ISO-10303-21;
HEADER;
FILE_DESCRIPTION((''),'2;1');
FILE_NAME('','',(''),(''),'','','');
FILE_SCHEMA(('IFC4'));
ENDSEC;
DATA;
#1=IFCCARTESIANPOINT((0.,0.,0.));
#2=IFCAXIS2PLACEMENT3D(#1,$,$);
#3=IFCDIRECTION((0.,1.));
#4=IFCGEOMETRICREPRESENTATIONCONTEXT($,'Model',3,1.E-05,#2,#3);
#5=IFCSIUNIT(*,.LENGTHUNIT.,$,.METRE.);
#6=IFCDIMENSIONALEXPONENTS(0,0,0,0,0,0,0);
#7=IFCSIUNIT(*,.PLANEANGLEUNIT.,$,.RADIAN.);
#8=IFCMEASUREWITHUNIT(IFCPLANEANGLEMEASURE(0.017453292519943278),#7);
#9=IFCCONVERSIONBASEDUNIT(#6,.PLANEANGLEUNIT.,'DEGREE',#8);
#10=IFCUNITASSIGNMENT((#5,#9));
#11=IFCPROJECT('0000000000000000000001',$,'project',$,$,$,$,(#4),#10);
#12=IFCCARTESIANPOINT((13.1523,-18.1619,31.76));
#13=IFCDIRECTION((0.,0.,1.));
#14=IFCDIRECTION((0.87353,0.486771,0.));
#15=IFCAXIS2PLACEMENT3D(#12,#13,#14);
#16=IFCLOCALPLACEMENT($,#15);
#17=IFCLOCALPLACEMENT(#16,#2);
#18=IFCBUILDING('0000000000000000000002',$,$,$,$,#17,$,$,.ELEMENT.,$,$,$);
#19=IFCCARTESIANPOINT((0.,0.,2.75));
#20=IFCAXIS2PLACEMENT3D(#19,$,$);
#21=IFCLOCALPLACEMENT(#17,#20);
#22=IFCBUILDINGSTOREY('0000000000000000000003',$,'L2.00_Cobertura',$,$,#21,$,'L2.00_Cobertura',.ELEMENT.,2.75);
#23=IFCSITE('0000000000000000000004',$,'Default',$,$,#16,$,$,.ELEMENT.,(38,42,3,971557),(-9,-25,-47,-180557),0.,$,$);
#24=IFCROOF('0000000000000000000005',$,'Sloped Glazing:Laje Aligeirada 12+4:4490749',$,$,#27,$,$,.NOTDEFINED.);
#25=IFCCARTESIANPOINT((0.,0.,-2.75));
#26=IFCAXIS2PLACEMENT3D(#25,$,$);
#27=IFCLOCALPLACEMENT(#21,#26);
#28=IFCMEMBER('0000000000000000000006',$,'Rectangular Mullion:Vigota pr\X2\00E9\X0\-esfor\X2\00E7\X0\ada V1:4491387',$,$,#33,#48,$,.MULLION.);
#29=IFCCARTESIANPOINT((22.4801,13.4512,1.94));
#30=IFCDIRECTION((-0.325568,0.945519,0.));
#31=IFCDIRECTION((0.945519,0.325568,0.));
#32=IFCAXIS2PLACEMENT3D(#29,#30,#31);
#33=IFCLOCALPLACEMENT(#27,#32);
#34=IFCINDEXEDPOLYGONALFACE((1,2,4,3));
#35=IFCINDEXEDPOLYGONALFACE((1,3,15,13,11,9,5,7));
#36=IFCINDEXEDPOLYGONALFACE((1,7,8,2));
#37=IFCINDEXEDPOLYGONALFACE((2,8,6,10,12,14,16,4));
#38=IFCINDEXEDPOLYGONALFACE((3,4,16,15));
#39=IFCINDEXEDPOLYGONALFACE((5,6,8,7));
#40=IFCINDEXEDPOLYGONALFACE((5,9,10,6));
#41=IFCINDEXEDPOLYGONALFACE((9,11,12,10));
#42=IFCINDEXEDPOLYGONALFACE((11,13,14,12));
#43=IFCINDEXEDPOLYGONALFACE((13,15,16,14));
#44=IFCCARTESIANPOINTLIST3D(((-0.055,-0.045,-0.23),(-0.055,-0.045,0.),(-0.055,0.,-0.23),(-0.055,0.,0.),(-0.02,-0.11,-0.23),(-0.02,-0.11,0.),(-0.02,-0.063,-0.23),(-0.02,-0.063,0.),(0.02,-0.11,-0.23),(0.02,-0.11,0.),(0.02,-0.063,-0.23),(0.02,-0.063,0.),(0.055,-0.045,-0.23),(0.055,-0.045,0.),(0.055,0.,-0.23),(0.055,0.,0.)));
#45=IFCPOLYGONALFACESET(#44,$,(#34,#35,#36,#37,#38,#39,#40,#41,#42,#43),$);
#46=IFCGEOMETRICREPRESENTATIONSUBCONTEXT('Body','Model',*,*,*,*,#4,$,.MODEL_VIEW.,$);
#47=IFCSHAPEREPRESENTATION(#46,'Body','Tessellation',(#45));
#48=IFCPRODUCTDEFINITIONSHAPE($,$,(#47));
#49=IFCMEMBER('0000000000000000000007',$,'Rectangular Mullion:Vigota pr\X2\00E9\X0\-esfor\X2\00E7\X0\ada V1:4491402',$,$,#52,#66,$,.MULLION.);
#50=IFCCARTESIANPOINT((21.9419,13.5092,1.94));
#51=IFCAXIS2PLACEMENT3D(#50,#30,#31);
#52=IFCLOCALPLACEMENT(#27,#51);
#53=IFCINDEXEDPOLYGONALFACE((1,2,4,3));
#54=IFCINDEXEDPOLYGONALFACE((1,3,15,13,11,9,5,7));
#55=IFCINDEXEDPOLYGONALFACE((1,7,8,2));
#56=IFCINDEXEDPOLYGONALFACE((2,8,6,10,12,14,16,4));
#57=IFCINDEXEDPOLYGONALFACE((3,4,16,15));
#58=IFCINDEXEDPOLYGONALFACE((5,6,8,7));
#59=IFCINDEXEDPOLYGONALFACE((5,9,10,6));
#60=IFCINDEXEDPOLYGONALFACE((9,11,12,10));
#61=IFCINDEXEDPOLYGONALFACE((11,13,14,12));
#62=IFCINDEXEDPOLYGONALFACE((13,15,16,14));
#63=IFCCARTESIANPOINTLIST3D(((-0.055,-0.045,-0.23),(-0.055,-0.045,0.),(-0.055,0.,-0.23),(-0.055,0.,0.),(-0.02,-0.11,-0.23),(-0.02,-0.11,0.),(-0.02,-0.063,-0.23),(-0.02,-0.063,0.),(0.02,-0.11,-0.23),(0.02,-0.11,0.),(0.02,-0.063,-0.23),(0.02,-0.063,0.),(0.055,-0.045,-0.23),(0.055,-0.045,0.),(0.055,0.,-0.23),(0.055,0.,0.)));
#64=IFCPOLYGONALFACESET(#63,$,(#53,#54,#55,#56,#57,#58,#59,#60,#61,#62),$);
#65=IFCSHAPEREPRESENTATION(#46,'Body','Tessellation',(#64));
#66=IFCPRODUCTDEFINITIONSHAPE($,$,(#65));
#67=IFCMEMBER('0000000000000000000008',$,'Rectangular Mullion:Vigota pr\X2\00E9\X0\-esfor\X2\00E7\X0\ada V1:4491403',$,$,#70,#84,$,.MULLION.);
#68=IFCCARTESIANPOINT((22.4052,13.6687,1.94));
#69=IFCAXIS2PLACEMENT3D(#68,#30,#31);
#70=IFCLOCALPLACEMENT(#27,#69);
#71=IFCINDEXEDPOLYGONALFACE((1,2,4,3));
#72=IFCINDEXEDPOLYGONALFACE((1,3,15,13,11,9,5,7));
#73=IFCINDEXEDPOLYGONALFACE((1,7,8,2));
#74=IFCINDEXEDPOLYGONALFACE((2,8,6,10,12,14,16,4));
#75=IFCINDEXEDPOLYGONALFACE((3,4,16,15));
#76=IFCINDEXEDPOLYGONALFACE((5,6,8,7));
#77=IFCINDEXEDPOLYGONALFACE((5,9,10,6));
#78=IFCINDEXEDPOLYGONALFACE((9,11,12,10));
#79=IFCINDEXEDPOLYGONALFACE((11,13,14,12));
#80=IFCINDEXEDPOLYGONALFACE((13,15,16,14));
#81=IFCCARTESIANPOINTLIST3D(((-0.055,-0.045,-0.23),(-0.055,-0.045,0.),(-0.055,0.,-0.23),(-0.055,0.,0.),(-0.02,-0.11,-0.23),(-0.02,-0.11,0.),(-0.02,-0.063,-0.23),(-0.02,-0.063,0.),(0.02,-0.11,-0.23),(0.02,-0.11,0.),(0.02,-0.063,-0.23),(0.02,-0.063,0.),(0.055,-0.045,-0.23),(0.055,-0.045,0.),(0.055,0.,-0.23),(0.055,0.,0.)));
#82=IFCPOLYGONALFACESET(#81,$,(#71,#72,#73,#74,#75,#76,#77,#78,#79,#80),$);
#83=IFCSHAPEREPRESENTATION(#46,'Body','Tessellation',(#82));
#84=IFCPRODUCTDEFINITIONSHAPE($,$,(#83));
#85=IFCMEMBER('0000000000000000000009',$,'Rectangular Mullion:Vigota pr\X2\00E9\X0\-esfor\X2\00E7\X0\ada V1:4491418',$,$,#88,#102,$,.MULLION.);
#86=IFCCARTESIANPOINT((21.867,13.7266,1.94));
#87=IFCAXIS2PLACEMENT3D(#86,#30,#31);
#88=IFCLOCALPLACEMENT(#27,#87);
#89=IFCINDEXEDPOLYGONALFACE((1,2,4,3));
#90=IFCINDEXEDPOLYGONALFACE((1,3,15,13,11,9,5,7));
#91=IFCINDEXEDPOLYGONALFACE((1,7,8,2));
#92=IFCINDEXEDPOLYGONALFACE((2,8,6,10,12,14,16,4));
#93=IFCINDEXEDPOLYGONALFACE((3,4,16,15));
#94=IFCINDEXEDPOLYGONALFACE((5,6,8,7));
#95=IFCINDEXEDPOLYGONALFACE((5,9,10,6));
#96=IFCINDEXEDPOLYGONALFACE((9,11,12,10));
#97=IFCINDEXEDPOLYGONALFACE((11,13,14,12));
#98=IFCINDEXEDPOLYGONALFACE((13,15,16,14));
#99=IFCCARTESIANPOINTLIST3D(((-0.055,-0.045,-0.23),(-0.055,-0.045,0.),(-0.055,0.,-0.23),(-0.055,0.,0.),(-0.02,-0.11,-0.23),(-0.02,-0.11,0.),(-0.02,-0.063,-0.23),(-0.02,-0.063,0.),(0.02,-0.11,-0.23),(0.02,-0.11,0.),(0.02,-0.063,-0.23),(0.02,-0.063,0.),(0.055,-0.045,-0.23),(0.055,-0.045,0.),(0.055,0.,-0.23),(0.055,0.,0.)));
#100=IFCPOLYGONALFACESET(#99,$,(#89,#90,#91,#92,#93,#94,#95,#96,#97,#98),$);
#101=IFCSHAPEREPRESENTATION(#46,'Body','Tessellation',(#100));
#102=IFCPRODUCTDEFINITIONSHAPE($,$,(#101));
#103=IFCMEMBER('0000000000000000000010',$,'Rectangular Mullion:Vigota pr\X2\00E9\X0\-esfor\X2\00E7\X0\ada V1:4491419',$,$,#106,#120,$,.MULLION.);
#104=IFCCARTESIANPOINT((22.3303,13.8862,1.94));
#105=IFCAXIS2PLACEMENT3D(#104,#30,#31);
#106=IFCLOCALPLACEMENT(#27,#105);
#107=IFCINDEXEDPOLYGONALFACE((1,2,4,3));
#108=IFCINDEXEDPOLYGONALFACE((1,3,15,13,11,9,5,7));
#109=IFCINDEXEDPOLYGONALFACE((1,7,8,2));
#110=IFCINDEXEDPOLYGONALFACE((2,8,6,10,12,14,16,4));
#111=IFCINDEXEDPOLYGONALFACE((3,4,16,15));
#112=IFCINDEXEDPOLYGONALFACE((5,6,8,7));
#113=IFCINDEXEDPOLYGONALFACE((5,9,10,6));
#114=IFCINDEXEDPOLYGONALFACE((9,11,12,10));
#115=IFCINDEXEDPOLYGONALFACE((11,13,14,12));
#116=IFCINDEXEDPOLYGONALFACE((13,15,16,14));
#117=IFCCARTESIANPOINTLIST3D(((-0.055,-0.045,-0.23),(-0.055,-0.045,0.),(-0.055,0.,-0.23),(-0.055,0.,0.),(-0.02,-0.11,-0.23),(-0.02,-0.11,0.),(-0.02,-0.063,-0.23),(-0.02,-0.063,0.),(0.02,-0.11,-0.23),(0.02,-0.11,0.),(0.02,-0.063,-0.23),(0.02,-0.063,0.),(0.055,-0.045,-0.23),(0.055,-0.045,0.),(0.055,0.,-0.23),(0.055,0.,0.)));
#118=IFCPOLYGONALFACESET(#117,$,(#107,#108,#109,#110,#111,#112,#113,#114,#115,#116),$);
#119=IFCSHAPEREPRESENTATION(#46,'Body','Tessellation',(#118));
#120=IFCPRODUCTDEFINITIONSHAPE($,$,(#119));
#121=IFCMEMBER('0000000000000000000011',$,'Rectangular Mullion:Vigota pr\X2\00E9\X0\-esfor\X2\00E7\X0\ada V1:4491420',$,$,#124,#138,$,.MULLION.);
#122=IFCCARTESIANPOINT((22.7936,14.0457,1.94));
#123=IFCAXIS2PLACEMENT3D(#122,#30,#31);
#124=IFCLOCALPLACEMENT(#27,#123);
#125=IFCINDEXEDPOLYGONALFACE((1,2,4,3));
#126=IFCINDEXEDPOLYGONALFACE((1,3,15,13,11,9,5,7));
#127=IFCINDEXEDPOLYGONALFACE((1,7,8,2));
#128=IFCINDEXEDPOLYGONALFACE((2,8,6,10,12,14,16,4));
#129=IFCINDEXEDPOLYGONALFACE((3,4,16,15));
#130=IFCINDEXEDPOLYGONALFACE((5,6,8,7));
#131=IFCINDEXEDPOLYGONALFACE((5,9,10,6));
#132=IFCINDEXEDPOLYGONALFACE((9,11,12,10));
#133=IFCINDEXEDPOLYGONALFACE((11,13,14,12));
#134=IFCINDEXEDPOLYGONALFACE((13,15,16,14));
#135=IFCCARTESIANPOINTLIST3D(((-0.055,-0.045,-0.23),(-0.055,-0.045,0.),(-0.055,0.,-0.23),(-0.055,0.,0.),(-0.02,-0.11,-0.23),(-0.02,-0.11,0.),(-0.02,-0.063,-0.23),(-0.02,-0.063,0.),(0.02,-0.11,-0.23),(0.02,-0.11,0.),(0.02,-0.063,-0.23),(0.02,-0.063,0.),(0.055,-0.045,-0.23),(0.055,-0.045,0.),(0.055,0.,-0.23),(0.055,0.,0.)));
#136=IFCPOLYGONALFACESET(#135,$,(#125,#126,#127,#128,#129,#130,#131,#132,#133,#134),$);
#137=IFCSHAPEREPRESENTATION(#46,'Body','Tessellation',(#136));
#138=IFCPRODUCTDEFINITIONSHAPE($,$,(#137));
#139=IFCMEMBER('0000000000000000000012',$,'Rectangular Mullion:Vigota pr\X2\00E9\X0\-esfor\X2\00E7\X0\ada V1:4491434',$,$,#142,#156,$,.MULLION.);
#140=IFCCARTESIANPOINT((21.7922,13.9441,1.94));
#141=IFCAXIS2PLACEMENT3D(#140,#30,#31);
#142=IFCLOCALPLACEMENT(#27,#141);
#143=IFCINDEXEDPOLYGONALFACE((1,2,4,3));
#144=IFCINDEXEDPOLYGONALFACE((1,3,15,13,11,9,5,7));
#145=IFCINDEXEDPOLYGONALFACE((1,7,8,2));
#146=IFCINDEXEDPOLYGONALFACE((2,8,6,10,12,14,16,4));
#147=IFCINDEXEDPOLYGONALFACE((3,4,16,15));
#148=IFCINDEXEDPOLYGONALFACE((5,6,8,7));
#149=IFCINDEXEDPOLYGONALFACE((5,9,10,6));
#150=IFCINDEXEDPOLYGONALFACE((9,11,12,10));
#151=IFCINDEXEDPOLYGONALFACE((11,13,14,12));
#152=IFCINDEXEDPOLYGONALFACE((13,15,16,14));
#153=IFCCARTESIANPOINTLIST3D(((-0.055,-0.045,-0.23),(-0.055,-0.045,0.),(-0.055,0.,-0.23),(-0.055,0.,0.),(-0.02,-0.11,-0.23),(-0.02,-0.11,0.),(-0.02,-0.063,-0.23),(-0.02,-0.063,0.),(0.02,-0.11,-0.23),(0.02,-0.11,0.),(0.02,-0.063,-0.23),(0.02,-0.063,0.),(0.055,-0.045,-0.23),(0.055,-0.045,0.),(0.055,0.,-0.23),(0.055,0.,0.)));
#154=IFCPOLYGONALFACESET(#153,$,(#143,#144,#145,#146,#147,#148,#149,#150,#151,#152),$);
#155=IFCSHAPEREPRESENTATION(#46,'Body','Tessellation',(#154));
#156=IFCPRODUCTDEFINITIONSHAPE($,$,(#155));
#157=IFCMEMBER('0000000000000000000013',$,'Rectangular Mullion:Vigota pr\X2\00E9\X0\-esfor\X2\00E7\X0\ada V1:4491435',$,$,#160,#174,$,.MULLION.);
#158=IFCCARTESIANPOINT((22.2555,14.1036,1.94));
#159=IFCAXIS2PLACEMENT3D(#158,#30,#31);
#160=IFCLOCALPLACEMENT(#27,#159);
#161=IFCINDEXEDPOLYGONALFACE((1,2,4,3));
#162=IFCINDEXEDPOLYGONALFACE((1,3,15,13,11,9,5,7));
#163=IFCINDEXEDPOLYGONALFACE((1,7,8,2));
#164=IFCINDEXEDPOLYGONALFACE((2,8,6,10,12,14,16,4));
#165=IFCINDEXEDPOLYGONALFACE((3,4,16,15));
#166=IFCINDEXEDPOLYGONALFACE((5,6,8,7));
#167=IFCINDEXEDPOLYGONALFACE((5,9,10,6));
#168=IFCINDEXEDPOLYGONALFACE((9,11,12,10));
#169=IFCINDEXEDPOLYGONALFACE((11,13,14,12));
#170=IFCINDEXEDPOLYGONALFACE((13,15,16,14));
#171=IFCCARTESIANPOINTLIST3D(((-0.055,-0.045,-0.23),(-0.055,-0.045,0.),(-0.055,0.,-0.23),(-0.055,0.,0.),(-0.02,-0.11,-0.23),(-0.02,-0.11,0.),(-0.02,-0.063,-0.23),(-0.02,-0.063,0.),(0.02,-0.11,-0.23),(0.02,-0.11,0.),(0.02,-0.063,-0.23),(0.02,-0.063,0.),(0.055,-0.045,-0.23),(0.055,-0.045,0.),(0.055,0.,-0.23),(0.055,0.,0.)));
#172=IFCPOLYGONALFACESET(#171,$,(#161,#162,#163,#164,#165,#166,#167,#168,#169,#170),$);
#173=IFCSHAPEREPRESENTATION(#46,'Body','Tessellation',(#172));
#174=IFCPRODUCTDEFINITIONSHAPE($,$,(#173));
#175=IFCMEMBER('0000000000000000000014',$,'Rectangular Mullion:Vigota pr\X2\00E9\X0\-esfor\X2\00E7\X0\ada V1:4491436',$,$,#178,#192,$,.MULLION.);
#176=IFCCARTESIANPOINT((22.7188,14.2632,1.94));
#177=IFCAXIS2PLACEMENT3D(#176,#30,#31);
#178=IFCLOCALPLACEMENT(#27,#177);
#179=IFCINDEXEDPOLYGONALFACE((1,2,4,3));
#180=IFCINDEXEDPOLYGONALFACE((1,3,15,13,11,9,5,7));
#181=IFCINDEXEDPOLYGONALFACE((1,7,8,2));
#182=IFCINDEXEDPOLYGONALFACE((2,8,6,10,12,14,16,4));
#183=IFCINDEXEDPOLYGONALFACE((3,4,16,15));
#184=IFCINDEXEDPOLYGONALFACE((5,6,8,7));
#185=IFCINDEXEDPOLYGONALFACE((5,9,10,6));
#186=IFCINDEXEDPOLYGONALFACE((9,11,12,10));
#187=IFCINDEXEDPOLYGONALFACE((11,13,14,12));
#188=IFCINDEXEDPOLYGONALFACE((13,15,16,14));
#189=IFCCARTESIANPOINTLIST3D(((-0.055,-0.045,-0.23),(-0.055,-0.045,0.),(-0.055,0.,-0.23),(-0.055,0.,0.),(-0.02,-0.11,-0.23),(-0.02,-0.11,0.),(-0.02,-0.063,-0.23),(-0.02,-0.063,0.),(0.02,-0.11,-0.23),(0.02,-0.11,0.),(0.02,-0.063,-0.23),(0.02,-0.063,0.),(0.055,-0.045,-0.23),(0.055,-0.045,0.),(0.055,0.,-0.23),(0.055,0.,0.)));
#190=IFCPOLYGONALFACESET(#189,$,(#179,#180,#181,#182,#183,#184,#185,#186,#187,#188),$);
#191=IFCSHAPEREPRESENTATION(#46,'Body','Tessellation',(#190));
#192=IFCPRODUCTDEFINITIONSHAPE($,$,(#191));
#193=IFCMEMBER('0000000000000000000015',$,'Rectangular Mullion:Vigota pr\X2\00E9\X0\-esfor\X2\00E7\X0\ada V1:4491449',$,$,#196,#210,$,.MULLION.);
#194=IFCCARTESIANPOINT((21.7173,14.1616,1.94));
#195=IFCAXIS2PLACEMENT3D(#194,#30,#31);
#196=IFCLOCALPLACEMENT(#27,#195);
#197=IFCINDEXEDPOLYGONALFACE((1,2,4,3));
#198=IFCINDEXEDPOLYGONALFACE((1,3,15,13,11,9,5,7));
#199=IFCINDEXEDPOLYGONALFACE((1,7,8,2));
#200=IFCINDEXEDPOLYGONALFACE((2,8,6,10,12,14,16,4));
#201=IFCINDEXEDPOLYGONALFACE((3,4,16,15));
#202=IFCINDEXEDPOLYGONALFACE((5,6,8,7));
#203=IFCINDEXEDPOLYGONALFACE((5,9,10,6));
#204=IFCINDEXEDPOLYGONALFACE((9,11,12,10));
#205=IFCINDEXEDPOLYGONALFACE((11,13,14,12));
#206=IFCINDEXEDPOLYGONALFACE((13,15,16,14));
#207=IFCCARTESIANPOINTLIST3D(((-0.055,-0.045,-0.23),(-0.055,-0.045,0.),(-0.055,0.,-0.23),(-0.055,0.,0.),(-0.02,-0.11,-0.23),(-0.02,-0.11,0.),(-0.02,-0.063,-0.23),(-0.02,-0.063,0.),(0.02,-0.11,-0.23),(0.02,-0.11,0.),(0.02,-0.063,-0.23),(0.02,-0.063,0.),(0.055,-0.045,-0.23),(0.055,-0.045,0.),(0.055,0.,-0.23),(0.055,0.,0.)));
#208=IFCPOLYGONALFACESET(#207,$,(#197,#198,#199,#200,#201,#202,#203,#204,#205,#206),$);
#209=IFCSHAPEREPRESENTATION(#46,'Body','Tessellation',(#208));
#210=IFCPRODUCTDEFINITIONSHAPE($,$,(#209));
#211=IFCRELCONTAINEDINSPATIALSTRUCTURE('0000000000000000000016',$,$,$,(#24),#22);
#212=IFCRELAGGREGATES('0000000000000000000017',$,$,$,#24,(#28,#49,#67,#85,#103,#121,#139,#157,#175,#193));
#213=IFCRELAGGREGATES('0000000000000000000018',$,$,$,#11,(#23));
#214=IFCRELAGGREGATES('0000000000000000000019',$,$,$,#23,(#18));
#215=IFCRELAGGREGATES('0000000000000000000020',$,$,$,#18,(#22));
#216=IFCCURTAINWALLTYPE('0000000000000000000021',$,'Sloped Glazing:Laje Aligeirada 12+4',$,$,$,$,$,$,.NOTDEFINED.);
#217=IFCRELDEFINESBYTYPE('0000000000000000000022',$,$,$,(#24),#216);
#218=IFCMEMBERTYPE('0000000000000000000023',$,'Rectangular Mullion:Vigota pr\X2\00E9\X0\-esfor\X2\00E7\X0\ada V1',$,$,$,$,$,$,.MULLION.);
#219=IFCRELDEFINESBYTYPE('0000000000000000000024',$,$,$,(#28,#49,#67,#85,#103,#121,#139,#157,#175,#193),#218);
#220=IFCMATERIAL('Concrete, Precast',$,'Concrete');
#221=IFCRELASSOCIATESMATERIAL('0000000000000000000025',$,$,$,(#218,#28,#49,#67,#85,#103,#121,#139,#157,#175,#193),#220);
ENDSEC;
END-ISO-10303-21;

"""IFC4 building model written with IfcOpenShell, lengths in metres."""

from ifc_helpers import new_model, entity, si_unit, converted_unit, direction, frame, origin, place, context, subcontext, project, spatial, indexed_curve, outline, extrude, source, transform, mapped, material, type_object, type_shapes, element, aggregate, save


model = new_model("IFC4")

# Units and contexts
model_context = context("Model", 3, precision=1e-05, world=origin(), true_north=direction((0.0, 1.0)))
body_context = subcontext(model_context, "Body", "Model", "MODEL_VIEW")
ifc_project = project(units=[si_unit("LENGTHUNIT", "METRE"), converted_unit("PLANEANGLEUNIT", "DEGREE", entity("IfcPlaneAngleMeasure", 0.017453292519943278), si_unit("PLANEANGLEUNIT", "RADIAN"), dimensions=[0, 0, 0, 0, 0, 0, 0])], contexts=[model_context])

# Site, building, storey
site_placement = place(None, frame((13.1523, -18.1619, 31.76), z_axis=(0.0, 0.0, 1.0), x_axis=(0.87353, 0.486771, 0.0)))
site = spatial("IfcSite", under=ifc_project, at=site_placement, Name="Default", CompositionType="ELEMENT", RefLatitude=(38, 42, 3, 971557), RefLongitude=(-9, -25, -47, -180557), RefElevation=0.0)
building_placement = place(site_placement, origin())
building = spatial("IfcBuilding", under=site, at=building_placement, CompositionType="ELEMENT")
storey_placement = place(building_placement, frame((0.0, 0.0, 2.75)))
storey = spatial("IfcBuildingStorey", under=building, at=storey_placement, Name="L2.00_Cobertura", LongName="L2.00_Cobertura", CompositionType="ELEMENT", Elevation=2.75)

# Roof, members
curtain_wall_type = type_object("IfcCurtainWallType", Name="Sloped Glazing:Laje Aligeirada 12+4", PredefinedType="NOTDEFINED")
roof_placement = place(storey_placement, frame((0.0, 0.0, -2.75)))
roof = element("IfcRoof", 1, at=roof_placement, inside=storey, type_object=curtain_wall_type, Name="Sloped Glazing:Laje Aligeirada 12+4:4490749", PredefinedType="NOTDEFINED")
ifc_material_1 = material(Name="Concrete, Precast", Category="Concrete")
member_type_1 = type_object("IfcMemberType", Name="Rectangular Mullion:Vigota pré-esforçada V1", PredefinedType="MULLION", material=ifc_material_1)
shared_shape_1 = source(origin(), body_context, "Body", "SweptSolid", [
    extrude(outline(indexed_curve([(-0.055, -0.0545), (0.055, -0.0545), (0.055, -0.0095), (0.02, 0.0085), (0.02, 0.0555), (-0.02, 0.0555), (-0.02, 0.0085), (-0.055, -0.0095), (-0.055, -0.0545)], self_intersect=False)), frame((0.0, -0.0545, -0.23), z_axis=(0.0, 0.0, 1.0), x_axis=(-1.0, 0.0, 0.0)), (0.0, 0.0, 1.0), 0.23),
])
type_shapes(member_type_1, [shared_shape_1])
member_1_placement = place(roof_placement, frame((22.4801, 13.4512, 1.94), z_axis=(-0.325568, 0.945519, 0.0), x_axis=(0.945519, 0.325568, 0.0)))
member_1 = element("IfcMember", 2, at=member_1_placement, type_object=member_type_1, material=ifc_material_1, Name="Rectangular Mullion:Vigota pré-esforçada V1:4491387", PredefinedType="MULLION", context=body_context, shape_type="MappedRepresentation", body=[
    mapped(shared_shape_1, transform((0.0, 0.0, 0.0), scale=1.0)),
])
member_2_placement = place(roof_placement, frame((21.9419, 13.5092, 1.94), z_axis=(-0.325568, 0.945519, 0.0), x_axis=(0.945519, 0.325568, 0.0)))
member_2 = element("IfcMember", 3, at=member_2_placement, type_object=member_type_1, material=ifc_material_1, Name="Rectangular Mullion:Vigota pré-esforçada V1:4491402", PredefinedType="MULLION", context=body_context, shape_type="MappedRepresentation", body=[
    mapped(shared_shape_1, transform((0.0, 0.0, 0.0), scale=1.0)),
])
member_3_placement = place(roof_placement, frame((22.4052, 13.6687, 1.94), z_axis=(-0.325568, 0.945519, 0.0), x_axis=(0.945519, 0.325568, 0.0)))
member_3 = element("IfcMember", 4, at=member_3_placement, type_object=member_type_1, material=ifc_material_1, Name="Rectangular Mullion:Vigota pré-esforçada V1:4491403", PredefinedType="MULLION", context=body_context, shape_type="MappedRepresentation", body=[
    mapped(shared_shape_1, transform((0.0, 0.0, 0.0), scale=1.0)),
])
member_4_placement = place(roof_placement, frame((21.867, 13.7266, 1.94), z_axis=(-0.325568, 0.945519, 0.0), x_axis=(0.945519, 0.325568, 0.0)))
member_4 = element("IfcMember", 5, at=member_4_placement, type_object=member_type_1, material=ifc_material_1, Name="Rectangular Mullion:Vigota pré-esforçada V1:4491418", PredefinedType="MULLION", context=body_context, shape_type="MappedRepresentation", body=[
    mapped(shared_shape_1, transform((0.0, 0.0, 0.0), scale=1.0)),
])
member_5_placement = place(roof_placement, frame((22.3303, 13.8862, 1.94), z_axis=(-0.325568, 0.945519, 0.0), x_axis=(0.945519, 0.325568, 0.0)))
member_5 = element("IfcMember", 6, at=member_5_placement, type_object=member_type_1, material=ifc_material_1, Name="Rectangular Mullion:Vigota pré-esforçada V1:4491419", PredefinedType="MULLION", context=body_context, shape_type="MappedRepresentation", body=[
    mapped(shared_shape_1, transform((0.0, 0.0, 0.0), scale=1.0)),
])
member_6_placement = place(roof_placement, frame((22.7936, 14.0457, 1.94), z_axis=(-0.325568, 0.945519, 0.0), x_axis=(0.945519, 0.325568, 0.0)))
member_6 = element("IfcMember", 7, at=member_6_placement, type_object=member_type_1, material=ifc_material_1, Name="Rectangular Mullion:Vigota pré-esforçada V1:4491420", PredefinedType="MULLION", context=body_context, shape_type="MappedRepresentation", body=[
    mapped(shared_shape_1, transform((0.0, 0.0, 0.0), scale=1.0)),
])
member_7_placement = place(roof_placement, frame((21.7922, 13.9441, 1.94), z_axis=(-0.325568, 0.945519, 0.0), x_axis=(0.945519, 0.325568, 0.0)))
member_7 = element("IfcMember", 8, at=member_7_placement, type_object=member_type_1, material=ifc_material_1, Name="Rectangular Mullion:Vigota pré-esforçada V1:4491434", PredefinedType="MULLION", context=body_context, shape_type="MappedRepresentation", body=[
    mapped(shared_shape_1, transform((0.0, 0.0, 0.0), scale=1.0)),
])
member_8_placement = place(roof_placement, frame((22.2555, 14.1036, 1.94), z_axis=(-0.325568, 0.945519, 0.0), x_axis=(0.945519, 0.325568, 0.0)))
member_8 = element("IfcMember", 9, at=member_8_placement, type_object=member_type_1, material=ifc_material_1, Name="Rectangular Mullion:Vigota pré-esforçada V1:4491435", PredefinedType="MULLION", context=body_context, shape_type="MappedRepresentation", body=[
    mapped(shared_shape_1, transform((0.0, 0.0, 0.0), scale=1.0)),
])
member_9_placement = place(roof_placement, frame((22.7188, 14.2632, 1.94), z_axis=(-0.325568, 0.945519, 0.0), x_axis=(0.945519, 0.325568, 0.0)))
member_9 = element("IfcMember", 10, at=member_9_placement, type_object=member_type_1, material=ifc_material_1, Name="Rectangular Mullion:Vigota pré-esforçada V1:4491436", PredefinedType="MULLION", context=body_context, shape_type="MappedRepresentation", body=[
    mapped(shared_shape_1, transform((0.0, 0.0, 0.0), scale=1.0)),
])
member_10_placement = place(roof_placement, frame((21.7173, 14.1616, 1.94), z_axis=(-0.325568, 0.945519, 0.0), x_axis=(0.945519, 0.325568, 0.0)))
member_10 = element("IfcMember", 11, at=member_10_placement, type_object=member_type_1, material=ifc_material_1, Name="Rectangular Mullion:Vigota pré-esforçada V1:4491449", PredefinedType="MULLION", context=body_context, shape_type="MappedRepresentation", body=[
    mapped(shared_shape_1, transform((0.0, 0.0, 0.0), scale=1.0)),
])
aggregate(roof, [member_1, member_2, member_3, member_4, member_5, member_6, member_7, member_8, member_9, member_10])

save(model, "model.ifc")
